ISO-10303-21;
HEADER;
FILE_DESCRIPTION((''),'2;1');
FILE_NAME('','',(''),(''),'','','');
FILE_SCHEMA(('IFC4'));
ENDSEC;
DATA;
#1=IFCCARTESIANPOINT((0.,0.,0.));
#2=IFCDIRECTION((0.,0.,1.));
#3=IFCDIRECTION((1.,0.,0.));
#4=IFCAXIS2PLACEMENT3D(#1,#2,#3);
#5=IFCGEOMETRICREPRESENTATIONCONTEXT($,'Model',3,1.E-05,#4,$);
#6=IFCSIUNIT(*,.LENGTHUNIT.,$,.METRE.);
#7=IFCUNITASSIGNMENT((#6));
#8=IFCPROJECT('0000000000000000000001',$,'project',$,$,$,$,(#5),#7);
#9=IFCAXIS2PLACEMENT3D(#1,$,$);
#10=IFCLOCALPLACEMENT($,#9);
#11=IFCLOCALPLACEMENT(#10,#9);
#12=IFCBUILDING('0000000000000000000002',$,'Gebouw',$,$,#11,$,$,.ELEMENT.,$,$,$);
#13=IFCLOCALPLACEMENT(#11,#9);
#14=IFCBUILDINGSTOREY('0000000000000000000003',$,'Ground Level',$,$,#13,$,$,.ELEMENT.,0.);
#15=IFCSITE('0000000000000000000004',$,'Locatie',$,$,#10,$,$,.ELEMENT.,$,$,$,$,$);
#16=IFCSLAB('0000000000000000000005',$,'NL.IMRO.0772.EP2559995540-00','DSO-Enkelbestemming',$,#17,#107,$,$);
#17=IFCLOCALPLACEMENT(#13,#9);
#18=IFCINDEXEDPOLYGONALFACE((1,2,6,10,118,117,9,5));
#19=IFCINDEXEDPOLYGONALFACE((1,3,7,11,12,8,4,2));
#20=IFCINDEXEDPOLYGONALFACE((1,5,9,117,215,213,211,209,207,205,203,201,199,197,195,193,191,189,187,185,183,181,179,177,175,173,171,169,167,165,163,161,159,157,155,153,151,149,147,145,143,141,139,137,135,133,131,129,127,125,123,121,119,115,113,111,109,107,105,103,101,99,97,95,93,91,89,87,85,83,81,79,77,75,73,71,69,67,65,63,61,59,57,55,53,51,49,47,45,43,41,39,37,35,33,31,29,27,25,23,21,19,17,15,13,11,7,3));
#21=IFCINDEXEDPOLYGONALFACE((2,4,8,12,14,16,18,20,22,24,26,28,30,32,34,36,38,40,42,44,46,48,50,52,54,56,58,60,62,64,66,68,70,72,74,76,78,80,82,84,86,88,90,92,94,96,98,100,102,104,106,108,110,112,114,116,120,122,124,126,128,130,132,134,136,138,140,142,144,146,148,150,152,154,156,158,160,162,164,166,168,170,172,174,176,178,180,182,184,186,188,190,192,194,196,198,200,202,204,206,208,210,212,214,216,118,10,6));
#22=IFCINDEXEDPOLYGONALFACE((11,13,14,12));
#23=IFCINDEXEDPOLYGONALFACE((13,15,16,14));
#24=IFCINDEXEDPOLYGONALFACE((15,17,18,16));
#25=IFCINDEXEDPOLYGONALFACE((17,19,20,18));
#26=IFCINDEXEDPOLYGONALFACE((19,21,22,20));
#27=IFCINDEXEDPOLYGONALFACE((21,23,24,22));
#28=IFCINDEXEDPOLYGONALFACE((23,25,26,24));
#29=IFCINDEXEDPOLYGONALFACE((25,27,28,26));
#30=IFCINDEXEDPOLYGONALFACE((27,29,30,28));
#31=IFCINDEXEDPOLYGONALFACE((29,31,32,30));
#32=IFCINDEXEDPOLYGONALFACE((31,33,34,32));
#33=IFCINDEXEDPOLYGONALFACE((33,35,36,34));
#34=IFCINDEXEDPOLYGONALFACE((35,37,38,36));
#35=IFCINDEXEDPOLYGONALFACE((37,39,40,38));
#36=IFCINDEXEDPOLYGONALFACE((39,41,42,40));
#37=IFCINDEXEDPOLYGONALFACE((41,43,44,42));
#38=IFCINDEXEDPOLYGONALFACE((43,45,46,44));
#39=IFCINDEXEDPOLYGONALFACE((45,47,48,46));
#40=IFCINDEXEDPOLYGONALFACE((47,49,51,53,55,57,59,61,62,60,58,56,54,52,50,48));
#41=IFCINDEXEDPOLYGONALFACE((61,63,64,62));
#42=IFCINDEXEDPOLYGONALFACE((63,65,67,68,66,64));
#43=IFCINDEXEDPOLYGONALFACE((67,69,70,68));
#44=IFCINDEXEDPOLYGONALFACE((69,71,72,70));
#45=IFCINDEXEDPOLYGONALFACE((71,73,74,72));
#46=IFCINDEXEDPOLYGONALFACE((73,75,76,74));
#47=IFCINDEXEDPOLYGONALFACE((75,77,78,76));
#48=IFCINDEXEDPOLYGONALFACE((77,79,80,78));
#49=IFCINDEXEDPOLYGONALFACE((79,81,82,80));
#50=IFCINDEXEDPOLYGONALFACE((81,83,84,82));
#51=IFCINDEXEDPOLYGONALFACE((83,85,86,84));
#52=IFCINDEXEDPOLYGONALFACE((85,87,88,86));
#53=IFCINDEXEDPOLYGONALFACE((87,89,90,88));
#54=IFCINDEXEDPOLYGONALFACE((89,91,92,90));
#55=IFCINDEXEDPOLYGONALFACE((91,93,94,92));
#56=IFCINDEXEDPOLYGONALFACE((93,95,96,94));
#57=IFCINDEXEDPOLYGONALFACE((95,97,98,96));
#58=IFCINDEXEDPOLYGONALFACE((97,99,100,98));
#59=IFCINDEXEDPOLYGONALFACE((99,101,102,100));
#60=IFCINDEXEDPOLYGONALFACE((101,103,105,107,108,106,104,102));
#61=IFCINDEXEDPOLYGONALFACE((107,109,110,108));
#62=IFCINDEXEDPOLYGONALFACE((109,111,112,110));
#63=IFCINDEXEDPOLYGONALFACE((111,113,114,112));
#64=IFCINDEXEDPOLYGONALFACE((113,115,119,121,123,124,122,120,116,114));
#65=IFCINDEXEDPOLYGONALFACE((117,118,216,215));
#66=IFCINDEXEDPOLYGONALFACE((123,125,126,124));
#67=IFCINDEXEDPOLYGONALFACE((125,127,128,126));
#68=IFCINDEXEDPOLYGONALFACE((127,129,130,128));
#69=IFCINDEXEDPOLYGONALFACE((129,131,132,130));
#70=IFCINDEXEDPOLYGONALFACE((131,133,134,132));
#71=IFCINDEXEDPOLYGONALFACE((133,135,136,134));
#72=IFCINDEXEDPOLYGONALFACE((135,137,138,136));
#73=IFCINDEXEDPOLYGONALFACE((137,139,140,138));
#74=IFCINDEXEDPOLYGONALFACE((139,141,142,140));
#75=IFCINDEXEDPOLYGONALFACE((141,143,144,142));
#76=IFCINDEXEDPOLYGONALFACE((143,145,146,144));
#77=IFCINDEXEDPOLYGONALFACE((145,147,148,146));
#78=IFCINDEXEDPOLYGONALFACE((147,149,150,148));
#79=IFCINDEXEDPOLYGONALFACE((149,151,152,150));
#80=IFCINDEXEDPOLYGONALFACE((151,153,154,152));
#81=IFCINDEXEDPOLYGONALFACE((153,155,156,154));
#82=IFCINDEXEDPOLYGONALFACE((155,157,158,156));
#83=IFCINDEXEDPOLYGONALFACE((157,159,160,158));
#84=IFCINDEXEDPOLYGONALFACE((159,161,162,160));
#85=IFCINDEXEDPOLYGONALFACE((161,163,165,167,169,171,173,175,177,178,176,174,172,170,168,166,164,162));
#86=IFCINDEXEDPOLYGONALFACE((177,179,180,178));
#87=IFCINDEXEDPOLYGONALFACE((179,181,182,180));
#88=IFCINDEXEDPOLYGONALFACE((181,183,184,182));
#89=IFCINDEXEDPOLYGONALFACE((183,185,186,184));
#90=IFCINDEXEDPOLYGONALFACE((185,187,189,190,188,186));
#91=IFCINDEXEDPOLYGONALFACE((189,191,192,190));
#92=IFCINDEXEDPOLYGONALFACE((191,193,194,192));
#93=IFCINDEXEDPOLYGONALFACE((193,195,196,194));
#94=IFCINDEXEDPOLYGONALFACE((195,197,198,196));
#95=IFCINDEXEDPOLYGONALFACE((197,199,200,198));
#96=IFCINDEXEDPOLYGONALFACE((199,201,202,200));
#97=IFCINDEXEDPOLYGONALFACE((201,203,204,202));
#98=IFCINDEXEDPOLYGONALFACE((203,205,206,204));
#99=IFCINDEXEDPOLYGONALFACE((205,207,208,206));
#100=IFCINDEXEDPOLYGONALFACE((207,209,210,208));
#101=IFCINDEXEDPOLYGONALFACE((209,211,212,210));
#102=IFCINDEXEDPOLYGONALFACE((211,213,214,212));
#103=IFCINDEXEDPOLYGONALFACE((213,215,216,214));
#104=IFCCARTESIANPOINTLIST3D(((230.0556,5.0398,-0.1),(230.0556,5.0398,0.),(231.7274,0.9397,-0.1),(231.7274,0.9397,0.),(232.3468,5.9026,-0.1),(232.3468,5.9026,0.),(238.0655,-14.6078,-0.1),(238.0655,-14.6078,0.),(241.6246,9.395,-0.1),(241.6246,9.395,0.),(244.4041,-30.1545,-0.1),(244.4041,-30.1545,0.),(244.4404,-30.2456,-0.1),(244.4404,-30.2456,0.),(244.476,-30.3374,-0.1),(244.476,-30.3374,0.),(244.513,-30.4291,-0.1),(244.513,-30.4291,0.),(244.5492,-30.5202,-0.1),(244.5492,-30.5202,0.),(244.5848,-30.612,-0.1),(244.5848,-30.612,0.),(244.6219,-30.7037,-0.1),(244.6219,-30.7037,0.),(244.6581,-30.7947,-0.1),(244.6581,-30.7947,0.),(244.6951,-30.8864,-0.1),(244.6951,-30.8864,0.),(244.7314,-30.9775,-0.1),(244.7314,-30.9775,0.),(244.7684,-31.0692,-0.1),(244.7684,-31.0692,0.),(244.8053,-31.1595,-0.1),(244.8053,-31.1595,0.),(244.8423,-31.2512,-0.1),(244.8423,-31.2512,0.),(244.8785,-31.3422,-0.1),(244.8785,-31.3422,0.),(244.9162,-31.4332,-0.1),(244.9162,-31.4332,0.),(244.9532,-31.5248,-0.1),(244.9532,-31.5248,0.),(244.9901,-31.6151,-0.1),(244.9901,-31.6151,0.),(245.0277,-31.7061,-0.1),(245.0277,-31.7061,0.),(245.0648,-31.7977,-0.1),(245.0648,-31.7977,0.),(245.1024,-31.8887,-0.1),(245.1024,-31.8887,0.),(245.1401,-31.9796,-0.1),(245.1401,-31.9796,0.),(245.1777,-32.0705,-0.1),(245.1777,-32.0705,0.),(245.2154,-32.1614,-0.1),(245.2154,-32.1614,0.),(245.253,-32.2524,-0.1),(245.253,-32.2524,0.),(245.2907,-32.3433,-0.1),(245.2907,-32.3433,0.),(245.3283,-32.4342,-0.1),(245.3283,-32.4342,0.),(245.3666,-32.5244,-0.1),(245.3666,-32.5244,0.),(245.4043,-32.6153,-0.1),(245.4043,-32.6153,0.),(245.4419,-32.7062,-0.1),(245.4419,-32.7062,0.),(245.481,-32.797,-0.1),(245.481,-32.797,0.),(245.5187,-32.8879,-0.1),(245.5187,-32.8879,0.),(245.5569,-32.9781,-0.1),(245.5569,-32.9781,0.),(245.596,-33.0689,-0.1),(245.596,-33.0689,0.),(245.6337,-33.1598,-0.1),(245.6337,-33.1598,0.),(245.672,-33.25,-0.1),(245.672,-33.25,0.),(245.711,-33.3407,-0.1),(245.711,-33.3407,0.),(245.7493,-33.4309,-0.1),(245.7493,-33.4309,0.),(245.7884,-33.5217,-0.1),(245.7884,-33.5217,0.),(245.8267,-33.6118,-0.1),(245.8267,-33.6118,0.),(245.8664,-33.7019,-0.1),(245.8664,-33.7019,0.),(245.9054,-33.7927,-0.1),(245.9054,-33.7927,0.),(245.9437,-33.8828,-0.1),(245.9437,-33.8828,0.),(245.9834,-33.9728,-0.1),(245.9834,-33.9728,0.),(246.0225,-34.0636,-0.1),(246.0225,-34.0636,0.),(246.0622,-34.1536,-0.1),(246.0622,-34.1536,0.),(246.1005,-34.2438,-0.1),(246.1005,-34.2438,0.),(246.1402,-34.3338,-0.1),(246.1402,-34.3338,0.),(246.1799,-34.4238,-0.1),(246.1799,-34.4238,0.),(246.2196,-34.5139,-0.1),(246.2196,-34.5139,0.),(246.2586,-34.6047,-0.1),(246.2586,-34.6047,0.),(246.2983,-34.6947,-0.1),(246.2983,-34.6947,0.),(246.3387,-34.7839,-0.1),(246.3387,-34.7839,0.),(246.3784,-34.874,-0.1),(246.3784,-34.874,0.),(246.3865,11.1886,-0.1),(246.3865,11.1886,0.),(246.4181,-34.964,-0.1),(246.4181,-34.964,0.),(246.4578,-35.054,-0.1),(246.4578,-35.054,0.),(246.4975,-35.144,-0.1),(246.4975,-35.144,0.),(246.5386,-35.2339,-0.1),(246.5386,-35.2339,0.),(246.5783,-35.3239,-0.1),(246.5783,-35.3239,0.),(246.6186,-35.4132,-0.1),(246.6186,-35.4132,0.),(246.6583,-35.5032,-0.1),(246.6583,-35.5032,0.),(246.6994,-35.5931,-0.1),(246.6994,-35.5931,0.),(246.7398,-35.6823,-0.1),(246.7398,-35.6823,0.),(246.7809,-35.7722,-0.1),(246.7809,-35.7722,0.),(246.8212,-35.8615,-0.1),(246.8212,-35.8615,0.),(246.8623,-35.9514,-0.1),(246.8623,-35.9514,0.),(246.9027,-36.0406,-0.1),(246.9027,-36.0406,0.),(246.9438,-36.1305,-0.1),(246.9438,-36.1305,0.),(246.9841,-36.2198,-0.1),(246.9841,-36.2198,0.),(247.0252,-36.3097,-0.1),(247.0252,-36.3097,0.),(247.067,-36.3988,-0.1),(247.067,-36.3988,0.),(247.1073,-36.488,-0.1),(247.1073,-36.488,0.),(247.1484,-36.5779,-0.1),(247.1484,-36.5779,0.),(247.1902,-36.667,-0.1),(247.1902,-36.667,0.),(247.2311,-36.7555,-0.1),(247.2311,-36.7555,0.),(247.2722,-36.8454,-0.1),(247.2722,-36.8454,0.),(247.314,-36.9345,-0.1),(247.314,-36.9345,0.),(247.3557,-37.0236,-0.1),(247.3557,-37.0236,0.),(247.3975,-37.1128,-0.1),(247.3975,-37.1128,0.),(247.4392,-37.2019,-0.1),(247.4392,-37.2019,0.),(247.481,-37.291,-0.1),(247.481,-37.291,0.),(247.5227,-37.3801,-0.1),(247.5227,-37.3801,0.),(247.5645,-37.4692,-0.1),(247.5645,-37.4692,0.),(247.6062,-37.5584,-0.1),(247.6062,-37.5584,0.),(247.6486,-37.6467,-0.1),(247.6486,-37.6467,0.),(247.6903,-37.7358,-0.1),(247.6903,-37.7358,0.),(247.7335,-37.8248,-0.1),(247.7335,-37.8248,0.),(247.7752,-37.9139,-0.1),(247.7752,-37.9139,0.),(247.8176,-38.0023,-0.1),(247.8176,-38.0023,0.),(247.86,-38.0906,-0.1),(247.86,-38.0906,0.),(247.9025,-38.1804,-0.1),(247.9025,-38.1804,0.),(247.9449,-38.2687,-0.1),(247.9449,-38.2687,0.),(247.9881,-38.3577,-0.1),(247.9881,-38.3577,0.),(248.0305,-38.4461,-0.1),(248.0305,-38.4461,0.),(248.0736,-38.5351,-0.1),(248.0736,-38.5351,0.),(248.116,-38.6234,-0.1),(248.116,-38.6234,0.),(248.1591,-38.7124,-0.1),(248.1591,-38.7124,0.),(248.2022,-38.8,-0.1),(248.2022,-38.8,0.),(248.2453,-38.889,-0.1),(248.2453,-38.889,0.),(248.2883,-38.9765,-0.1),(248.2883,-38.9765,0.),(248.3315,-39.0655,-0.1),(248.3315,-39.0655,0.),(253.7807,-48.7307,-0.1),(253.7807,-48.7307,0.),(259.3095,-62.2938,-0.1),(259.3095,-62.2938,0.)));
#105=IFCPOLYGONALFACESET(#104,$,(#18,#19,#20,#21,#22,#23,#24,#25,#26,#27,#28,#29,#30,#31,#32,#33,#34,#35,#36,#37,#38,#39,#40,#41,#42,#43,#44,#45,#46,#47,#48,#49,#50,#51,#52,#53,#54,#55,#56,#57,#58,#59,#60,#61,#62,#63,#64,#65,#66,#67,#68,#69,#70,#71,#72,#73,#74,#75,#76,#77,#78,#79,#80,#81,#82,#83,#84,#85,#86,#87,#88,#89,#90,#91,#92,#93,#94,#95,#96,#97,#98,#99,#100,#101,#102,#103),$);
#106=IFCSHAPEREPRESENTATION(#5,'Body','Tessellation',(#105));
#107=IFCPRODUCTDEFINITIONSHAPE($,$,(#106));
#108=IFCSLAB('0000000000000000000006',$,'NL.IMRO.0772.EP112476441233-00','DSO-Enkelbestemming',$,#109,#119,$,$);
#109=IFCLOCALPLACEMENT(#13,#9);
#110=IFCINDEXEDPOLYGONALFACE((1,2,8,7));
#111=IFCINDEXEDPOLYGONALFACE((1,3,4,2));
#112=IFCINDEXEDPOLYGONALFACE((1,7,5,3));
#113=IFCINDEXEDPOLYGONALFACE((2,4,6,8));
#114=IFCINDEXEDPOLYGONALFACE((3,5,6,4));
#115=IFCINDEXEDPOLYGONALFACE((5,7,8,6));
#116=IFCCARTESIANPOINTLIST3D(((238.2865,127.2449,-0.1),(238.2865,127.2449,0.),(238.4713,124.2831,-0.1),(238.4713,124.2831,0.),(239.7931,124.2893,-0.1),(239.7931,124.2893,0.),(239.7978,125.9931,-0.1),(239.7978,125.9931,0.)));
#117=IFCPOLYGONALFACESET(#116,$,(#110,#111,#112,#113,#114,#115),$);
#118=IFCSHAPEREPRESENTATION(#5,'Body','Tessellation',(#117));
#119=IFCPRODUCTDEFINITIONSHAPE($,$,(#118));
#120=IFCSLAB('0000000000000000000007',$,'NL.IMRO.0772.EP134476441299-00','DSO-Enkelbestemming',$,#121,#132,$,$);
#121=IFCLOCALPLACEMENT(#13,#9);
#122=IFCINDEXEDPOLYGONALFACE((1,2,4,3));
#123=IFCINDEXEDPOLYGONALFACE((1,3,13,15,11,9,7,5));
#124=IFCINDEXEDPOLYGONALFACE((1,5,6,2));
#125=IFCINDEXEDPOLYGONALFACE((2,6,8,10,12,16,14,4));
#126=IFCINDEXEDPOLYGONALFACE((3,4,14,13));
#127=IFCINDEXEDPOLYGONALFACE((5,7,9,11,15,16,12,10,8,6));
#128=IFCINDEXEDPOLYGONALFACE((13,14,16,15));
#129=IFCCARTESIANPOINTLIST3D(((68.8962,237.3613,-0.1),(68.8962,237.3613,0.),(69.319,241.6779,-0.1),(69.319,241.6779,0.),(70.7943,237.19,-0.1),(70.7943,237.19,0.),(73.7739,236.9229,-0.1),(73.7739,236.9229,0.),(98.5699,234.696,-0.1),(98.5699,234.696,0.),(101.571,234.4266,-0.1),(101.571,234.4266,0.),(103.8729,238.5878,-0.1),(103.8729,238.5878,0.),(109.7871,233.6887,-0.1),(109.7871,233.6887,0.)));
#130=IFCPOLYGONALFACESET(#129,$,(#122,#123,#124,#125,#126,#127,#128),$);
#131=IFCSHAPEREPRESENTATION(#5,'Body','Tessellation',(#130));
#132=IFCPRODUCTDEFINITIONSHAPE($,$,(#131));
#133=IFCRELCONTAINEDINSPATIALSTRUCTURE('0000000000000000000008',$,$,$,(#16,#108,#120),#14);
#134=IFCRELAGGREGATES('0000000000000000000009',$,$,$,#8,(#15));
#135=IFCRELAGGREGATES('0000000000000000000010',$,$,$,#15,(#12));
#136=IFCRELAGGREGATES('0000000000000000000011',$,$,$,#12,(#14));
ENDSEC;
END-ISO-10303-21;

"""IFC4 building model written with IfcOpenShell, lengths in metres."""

from ifc_helpers import new_model, si_unit, frame, origin, origin_with_axes, place, context, project, spatial, polyline, outline, extrude, element, save


model = new_model("IFC4")

# Units and contexts
model_context = context("Model", 3, precision=1e-05, world=origin_with_axes())
ifc_project = project(units=[si_unit("LENGTHUNIT", "METRE")], contexts=[model_context])

# Site, building, storey
site_placement = place(None, origin())
site = spatial("IfcSite", under=ifc_project, at=site_placement, Name="Locatie", CompositionType="ELEMENT")
building_placement = place(site_placement, origin())
building = spatial("IfcBuilding", under=site, at=building_placement, Name="Gebouw", CompositionType="ELEMENT")
storey_placement = place(building_placement, origin())
storey = spatial("IfcBuildingStorey", under=building, at=storey_placement, Name="Ground Level", CompositionType="ELEMENT", Elevation=0.0)

# Slabs
slab_1_placement = place(storey_placement, origin())
element("IfcSlab", 1, at=slab_1_placement, inside=storey, Name="NL.IMRO.0772.EP2559995540-00", Description="DSO-Enkelbestemming", context=model_context, shape_type="SweptSolid", body=[
    extrude(outline(polyline([(238.0655, -14.6078), (231.7274, 0.9397), (230.0556, 5.0398), (232.3468, 5.9026), (241.6246, 9.395), (246.3865, 11.1886), (259.3095, -62.2938), (253.7807, -48.7307), (248.3315, -39.0655), (248.2883, -38.9765), (248.2453, -38.889), (248.2022, -38.8), (248.1591, -38.7124), (248.116, -38.6234), (248.0736, -38.5351), (248.0305, -38.4461), (247.9881, -38.3577), (247.9449, -38.2687), (247.9025, -38.1804), (247.86, -38.0906), (247.8176, -38.0023), (247.7752, -37.9139), (247.7335, -37.8248), (247.6903, -37.7358), (247.6486, -37.6467), (247.6062, -37.5584), (247.5645, -37.4692), (247.5227, -37.3801), (247.481, -37.291), (247.4392, -37.2019), (247.3975, -37.1128), (247.3557, -37.0236), (247.314, -36.9345), (247.2722, -36.8454), (247.2311, -36.7555), (247.1902, -36.667), (247.1484, -36.5779), (247.1073, -36.488), (247.067, -36.3988), (247.0252, -36.3097), (246.9841, -36.2198), (246.9438, -36.1305), (246.9027, -36.0406), (246.8623, -35.9514), (246.8212, -35.8615), (246.7809, -35.7722), (246.7398, -35.6823), (246.6994, -35.5931), (246.6583, -35.5032), (246.6186, -35.4132), (246.5783, -35.3239), (246.5386, -35.2339), (246.4975, -35.144), (246.4578, -35.054), (246.4181, -34.964), (246.3784, -34.874), (246.3387, -34.7839), (246.2983, -34.6947), (246.2586, -34.6047), (246.2196, -34.5139), (246.1799, -34.4238), (246.1402, -34.3338), (246.1005, -34.2438), (246.0622, -34.1536), (246.0225, -34.0636), (245.9834, -33.9728), (245.9437, -33.8828), (245.9054, -33.7927), (245.8664, -33.7019), (245.8267, -33.6118), (245.7884, -33.5217), (245.7493, -33.4309), (245.711, -33.3407), (245.672, -33.25), (245.6337, -33.1598), (245.596, -33.0689), (245.5569, -32.9781), (245.5187, -32.8879), (245.481, -32.797), (245.4419, -32.7062), (245.4043, -32.6153), (245.3666, -32.5244), (245.3283, -32.4342), (245.2907, -32.3433), (245.253, -32.2524), (245.2154, -32.1614), (245.1777, -32.0705), (245.1401, -31.9796), (245.1024, -31.8887), (245.0648, -31.7977), (245.0277, -31.7061), (244.9901, -31.6151), (244.9532, -31.5248), (244.9162, -31.4332), (244.8785, -31.3422), (244.8423, -31.2512), (244.8053, -31.1595), (244.7684, -31.0692), (244.7314, -30.9775), (244.6951, -30.8864), (244.6581, -30.7947), (244.6219, -30.7037), (244.5848, -30.612), (244.5492, -30.5202), (244.513, -30.4291), (244.476, -30.3374), (244.4404, -30.2456), (244.4041, -30.1545), (238.0655, -14.6078)])), frame((0.0, 0.0, -0.1), z_axis=(0.0, 0.0, 1.0), x_axis=(1.0, 0.0, 0.0)), (0.0, 0.0, 1.0), 0.1),
])
slab_2_placement = place(storey_placement, origin())
element("IfcSlab", 2, at=slab_2_placement, inside=storey, Name="NL.IMRO.0772.EP112476441233-00", Description="DSO-Enkelbestemming", context=model_context, shape_type="SweptSolid", body=[
    extrude(outline(polyline([(239.7931, 124.2893), (238.4713, 124.2831), (238.2865, 127.2449), (239.7978, 125.9931), (239.7931, 124.2893)])), frame((0.0, 0.0, -0.1), z_axis=(0.0, 0.0, 1.0), x_axis=(1.0, 0.0, 0.0)), (0.0, 0.0, 1.0), 0.1),
])
slab_3_placement = place(storey_placement, origin())
element("IfcSlab", 3, at=slab_3_placement, inside=storey, Name="NL.IMRO.0772.EP134476441299-00", Description="DSO-Enkelbestemming", context=model_context, shape_type="SweptSolid", body=[
    extrude(outline(polyline([(101.571, 234.4266), (98.5699, 234.696), (73.7739, 236.9229), (70.7943, 237.19), (68.8962, 237.3613), (69.319, 241.6779), (103.8729, 238.5878), (109.7871, 233.6887), (101.571, 234.4266)])), frame((0.0, 0.0, -0.1), z_axis=(0.0, 0.0, 1.0), x_axis=(1.0, 0.0, 0.0)), (0.0, 0.0, 1.0), 0.1),
])

save(model, "model.ifc")
